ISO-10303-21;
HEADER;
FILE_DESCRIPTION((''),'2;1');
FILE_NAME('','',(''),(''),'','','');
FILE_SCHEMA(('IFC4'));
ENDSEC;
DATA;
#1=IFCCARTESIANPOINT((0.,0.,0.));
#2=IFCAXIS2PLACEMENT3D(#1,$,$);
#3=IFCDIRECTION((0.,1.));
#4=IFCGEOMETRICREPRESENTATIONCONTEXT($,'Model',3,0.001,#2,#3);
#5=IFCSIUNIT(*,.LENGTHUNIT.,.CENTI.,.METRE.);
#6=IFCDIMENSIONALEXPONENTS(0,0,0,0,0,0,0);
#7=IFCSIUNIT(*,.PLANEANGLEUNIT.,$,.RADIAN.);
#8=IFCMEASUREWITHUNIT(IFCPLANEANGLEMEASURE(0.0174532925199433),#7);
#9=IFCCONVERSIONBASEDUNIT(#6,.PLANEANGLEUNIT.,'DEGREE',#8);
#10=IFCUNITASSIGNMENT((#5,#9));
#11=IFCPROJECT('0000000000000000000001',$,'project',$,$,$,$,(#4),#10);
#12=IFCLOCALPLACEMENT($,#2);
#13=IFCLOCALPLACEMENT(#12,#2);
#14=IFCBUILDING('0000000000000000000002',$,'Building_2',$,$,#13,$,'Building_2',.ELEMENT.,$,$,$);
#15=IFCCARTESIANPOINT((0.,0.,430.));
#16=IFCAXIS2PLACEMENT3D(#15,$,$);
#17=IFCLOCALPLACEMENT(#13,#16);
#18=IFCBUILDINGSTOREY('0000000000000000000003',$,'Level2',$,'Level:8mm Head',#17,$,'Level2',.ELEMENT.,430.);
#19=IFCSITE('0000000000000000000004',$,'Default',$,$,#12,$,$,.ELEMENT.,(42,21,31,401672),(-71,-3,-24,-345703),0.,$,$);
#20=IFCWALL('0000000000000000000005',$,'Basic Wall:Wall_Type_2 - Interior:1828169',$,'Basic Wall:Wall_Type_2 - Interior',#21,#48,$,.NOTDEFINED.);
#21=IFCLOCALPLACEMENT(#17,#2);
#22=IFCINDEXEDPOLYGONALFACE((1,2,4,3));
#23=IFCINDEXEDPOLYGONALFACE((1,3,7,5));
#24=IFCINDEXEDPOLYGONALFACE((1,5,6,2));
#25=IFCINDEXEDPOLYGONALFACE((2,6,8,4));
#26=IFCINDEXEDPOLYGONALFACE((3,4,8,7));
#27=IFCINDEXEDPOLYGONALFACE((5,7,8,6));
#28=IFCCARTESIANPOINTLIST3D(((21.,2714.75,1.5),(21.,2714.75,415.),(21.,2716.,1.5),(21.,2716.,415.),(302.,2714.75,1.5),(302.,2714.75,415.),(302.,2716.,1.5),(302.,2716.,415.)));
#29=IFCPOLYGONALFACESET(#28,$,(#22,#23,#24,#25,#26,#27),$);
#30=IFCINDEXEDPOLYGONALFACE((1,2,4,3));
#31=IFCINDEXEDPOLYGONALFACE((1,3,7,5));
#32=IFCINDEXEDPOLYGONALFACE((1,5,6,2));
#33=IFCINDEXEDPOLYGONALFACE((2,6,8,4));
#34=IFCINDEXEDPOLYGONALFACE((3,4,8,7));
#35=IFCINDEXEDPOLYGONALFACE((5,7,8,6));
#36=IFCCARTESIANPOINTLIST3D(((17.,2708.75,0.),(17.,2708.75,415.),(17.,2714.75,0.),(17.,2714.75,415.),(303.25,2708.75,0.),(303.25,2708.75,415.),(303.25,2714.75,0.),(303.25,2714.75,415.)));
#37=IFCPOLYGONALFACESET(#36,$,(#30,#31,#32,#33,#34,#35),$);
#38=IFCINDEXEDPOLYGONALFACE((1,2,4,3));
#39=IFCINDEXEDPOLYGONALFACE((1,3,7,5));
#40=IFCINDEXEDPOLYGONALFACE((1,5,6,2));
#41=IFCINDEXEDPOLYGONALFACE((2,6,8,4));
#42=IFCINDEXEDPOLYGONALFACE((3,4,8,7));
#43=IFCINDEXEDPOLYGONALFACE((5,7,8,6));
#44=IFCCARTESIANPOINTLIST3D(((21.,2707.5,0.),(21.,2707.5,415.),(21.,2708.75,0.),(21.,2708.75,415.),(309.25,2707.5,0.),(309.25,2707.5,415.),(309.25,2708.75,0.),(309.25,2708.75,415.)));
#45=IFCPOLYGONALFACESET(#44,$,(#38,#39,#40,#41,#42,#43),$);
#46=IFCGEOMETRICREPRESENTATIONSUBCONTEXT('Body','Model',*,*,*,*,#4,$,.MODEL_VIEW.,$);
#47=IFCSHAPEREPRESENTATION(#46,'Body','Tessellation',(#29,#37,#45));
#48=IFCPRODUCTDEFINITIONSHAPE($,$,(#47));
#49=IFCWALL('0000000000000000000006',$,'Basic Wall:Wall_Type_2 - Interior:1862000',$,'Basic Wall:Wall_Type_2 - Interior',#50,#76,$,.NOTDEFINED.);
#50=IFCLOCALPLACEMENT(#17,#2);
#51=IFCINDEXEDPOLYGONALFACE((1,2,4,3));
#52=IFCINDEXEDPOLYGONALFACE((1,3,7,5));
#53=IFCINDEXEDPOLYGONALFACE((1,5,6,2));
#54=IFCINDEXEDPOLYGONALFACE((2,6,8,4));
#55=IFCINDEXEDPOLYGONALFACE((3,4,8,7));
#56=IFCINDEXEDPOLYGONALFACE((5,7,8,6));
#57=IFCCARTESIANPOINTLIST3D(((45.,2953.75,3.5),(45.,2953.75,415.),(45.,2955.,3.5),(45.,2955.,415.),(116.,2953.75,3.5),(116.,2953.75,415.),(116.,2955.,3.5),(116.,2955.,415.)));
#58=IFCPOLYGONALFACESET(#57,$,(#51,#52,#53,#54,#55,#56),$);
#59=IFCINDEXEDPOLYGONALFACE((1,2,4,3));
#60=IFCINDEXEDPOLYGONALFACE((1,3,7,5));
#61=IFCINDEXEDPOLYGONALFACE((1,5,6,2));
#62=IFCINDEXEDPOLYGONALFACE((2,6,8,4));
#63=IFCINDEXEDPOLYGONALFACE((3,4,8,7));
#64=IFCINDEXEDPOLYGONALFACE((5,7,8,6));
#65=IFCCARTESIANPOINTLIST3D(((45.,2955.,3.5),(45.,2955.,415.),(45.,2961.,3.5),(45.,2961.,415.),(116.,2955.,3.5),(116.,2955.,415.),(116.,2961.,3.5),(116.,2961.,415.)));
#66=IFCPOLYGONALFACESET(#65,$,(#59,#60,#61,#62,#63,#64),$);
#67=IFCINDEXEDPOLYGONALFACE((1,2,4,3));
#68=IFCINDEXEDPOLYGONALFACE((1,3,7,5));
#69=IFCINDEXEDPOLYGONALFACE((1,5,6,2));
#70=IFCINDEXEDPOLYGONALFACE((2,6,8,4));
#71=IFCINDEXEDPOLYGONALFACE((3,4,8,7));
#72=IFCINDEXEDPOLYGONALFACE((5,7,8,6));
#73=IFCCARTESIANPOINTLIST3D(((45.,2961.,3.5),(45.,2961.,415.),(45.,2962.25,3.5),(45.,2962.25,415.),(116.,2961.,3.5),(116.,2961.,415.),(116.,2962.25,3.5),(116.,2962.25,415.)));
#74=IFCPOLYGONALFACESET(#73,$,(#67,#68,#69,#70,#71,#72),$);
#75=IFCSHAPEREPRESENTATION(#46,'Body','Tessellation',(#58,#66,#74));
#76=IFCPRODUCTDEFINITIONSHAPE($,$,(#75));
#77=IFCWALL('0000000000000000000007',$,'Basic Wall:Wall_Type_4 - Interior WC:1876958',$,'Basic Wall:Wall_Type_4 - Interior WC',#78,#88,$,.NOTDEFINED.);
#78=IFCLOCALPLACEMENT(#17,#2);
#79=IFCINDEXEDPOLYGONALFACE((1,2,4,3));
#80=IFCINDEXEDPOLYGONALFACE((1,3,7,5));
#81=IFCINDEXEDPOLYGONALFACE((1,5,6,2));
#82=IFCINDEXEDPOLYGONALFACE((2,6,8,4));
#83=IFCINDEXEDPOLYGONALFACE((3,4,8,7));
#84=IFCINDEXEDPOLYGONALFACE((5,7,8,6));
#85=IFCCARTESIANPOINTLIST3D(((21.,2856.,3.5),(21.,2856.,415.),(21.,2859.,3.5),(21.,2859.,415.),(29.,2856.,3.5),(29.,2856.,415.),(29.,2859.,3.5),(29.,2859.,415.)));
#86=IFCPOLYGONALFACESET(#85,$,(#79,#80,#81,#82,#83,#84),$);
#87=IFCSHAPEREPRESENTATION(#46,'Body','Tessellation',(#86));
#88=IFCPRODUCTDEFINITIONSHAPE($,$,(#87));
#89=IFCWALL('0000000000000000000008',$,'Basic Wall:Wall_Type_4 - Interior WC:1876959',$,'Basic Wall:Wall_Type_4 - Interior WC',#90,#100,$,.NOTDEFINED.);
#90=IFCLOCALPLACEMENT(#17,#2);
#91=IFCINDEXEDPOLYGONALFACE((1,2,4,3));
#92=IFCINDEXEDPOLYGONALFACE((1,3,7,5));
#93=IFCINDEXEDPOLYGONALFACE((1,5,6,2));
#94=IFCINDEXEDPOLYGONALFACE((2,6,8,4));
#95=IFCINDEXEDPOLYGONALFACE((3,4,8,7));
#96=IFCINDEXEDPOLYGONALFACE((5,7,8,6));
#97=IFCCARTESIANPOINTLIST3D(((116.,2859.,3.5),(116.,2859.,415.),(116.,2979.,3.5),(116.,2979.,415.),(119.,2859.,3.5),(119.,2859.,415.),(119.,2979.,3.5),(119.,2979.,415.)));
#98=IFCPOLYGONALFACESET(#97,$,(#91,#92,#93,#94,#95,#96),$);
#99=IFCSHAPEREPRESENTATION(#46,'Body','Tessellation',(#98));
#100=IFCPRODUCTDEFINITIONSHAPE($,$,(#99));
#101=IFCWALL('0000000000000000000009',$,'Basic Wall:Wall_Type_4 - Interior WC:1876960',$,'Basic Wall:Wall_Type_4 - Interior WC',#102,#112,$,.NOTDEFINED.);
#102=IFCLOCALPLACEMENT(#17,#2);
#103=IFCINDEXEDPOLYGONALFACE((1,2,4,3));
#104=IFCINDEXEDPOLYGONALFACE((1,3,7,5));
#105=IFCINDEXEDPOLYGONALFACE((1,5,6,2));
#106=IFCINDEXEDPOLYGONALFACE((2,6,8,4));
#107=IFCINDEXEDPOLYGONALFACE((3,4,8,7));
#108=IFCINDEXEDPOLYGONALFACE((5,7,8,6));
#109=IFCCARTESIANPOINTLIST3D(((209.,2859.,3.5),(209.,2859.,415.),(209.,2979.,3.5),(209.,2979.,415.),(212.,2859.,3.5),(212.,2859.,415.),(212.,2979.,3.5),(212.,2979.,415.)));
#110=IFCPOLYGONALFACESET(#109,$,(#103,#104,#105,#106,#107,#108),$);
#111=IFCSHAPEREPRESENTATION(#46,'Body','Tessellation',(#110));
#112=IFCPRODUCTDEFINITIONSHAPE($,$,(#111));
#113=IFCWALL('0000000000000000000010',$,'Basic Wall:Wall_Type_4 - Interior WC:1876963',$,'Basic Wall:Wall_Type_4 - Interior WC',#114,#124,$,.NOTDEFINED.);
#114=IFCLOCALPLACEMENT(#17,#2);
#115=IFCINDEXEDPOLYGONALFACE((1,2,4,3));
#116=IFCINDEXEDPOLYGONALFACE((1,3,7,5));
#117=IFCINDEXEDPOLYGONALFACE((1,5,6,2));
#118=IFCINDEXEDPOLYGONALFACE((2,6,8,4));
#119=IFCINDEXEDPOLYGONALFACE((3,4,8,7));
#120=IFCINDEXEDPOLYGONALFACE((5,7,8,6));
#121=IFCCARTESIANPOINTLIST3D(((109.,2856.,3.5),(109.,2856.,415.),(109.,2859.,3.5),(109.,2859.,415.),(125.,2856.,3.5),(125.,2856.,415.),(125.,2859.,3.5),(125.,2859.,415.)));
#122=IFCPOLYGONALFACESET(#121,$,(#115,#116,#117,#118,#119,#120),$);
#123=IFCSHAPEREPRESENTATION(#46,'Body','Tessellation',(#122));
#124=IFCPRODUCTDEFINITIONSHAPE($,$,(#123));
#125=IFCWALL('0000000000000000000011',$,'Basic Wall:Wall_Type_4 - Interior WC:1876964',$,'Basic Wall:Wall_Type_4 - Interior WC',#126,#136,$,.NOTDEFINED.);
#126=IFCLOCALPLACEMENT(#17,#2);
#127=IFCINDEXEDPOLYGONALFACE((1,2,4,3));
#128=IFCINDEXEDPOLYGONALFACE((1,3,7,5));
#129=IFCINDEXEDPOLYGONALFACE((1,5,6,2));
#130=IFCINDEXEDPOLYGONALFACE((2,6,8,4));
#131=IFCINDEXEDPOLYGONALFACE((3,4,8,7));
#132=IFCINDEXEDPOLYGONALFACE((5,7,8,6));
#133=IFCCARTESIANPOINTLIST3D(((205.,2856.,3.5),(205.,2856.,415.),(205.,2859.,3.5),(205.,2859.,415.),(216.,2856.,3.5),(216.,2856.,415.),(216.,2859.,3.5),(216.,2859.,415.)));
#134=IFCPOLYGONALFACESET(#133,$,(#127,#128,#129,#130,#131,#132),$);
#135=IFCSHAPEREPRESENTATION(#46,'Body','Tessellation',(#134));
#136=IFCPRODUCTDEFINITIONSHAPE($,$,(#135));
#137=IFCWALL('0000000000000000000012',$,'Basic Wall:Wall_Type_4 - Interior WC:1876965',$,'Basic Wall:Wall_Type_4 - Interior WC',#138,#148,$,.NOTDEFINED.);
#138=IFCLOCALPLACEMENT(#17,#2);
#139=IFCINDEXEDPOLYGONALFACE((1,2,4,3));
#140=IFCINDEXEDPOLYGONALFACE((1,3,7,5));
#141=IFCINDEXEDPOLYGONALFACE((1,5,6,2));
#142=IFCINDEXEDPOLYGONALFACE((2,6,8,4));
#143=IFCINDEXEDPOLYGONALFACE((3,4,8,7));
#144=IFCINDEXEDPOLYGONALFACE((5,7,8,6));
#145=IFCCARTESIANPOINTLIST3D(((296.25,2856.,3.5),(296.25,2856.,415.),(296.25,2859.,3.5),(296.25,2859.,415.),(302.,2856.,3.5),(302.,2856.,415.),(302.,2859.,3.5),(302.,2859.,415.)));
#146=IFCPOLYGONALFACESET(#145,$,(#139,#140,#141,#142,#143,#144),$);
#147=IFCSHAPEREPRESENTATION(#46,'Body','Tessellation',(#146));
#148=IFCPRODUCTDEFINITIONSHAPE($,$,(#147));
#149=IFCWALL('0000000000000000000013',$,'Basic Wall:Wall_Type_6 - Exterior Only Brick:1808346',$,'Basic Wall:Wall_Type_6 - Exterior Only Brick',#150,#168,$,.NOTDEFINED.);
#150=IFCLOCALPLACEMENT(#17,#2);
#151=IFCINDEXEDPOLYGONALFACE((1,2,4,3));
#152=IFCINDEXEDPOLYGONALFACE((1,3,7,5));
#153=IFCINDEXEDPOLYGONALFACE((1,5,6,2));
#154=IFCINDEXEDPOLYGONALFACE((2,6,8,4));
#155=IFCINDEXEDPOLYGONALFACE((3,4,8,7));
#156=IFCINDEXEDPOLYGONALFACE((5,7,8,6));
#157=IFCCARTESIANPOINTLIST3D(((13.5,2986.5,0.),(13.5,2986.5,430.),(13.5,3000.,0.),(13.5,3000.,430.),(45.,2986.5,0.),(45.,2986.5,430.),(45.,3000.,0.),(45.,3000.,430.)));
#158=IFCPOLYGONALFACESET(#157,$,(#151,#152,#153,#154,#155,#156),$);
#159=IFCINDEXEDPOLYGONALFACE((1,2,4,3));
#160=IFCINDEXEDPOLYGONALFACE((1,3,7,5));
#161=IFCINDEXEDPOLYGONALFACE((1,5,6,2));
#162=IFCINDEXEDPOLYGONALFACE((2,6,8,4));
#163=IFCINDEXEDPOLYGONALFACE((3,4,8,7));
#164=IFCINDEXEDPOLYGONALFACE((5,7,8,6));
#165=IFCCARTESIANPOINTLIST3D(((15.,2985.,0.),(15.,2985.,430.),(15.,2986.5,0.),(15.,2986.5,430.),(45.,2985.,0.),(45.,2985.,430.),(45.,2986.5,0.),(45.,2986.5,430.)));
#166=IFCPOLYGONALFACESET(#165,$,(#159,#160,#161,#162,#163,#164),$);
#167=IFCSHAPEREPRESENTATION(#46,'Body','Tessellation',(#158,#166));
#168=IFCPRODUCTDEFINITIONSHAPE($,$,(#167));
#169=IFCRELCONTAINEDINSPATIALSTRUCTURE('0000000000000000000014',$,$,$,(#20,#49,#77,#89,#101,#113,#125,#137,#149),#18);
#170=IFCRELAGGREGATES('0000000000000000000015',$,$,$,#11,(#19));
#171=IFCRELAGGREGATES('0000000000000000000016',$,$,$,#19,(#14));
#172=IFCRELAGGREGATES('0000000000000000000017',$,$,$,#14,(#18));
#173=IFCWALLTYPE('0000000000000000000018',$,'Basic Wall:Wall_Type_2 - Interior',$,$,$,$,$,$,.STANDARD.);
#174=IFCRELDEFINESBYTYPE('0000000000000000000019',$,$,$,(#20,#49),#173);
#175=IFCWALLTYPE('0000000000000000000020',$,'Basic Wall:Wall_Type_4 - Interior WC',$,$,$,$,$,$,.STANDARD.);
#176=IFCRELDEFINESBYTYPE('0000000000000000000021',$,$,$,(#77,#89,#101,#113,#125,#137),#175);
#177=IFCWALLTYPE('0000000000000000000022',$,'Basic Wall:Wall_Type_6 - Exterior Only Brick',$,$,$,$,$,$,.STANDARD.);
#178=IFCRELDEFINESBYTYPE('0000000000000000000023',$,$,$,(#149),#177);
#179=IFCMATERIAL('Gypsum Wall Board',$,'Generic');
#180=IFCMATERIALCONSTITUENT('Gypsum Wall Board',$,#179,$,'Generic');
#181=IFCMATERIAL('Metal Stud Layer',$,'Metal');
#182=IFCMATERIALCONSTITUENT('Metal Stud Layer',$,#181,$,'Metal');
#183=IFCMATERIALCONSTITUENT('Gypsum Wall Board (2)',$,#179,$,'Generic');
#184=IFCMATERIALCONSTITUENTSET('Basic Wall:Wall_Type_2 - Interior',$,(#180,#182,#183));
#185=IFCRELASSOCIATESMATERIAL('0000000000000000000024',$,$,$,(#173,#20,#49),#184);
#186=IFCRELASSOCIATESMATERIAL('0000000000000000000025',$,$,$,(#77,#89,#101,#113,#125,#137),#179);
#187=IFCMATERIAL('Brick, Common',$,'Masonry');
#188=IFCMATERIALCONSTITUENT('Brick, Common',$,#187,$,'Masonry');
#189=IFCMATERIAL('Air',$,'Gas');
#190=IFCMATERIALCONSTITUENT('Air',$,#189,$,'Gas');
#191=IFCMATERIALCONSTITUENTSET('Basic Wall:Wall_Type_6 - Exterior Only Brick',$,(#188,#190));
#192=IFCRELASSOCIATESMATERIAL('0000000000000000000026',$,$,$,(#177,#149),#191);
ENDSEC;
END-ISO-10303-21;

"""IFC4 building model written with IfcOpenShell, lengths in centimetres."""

from ifc_helpers import new_model, entity, si_unit, converted_unit, direction, frame, origin, place, context, subcontext, project, spatial, indexed_curve, outline, extrude, material, constituent, constituent_set, type_object, element, save


model = new_model("IFC4")

# Units and contexts
model_context = context("Model", 3, precision=0.001, world=origin(), true_north=direction((0.0, 1.0)))
body_context = subcontext(model_context, "Body", "Model", "MODEL_VIEW")
ifc_project = project(units=[si_unit("LENGTHUNIT", "METRE", prefix="CENTI"), converted_unit("PLANEANGLEUNIT", "DEGREE", entity("IfcPlaneAngleMeasure", 0.0174532925199433), si_unit("PLANEANGLEUNIT", "RADIAN"), dimensions=[0, 0, 0, 0, 0, 0, 0])], contexts=[model_context])

# Site, building, storey
site_placement = place(None, origin())
site = spatial("IfcSite", under=ifc_project, at=site_placement, Name="Default", CompositionType="ELEMENT", RefLatitude=(42, 21, 31, 401672), RefLongitude=(-71, -3, -24, -345703), RefElevation=0.0)
building_placement = place(site_placement, origin())
building = spatial("IfcBuilding", under=site, at=building_placement, Name="Building_2", LongName="Building_2", CompositionType="ELEMENT")
storey_placement = place(building_placement, frame((0.0, 0.0, 430.0)))
storey = spatial("IfcBuildingStorey", under=building, at=storey_placement, Name="Level2", ObjectType="Level:8mm Head", LongName="Level2", CompositionType="ELEMENT", Elevation=430.0)

# Shared definitions
ifc_material_1 = material(Name="Brick, Common", Category="Masonry")
ifc_material_2 = material(Name="Air", Category="Gas")
ifc_material_3 = material(Name="Metal Stud Layer", Category="Metal")
ifc_material_4 = material(Name="Gypsum Wall Board", Category="Generic")

# Walls
ifc_constituent_1 = constituent(ifc_material_4, Name="Gypsum Wall Board", Category="Generic")
ifc_constituent_2 = constituent(ifc_material_3, Name="Metal Stud Layer", Category="Metal")
ifc_constituent_3 = constituent(ifc_material_4, Name="Gypsum Wall Board (2)", Category="Generic")
ifc_constituent_set_1 = constituent_set(constituents=[ifc_constituent_1, ifc_constituent_2, ifc_constituent_3], Name="Basic Wall:Wall_Type_2 - Interior")
wall_type_1 = type_object("IfcWallType", Name="Basic Wall:Wall_Type_2 - Interior", PredefinedType="STANDARD", material=ifc_constituent_set_1)
wall_1_placement = place(storey_placement, frame((302.0, 2711.75, 0.0), z_axis=(0.0, 0.0, 1.0), x_axis=(-1.0, 0.0, 0.0)))
element("IfcWall", 1, at=wall_1_placement, inside=storey, type_object=wall_type_1, material=ifc_constituent_set_1, Name="Basic Wall:Wall_Type_2 - Interior:1828169", ObjectType="Basic Wall:Wall_Type_2 - Interior", PredefinedType="NOTDEFINED", context=body_context, shape_type="SweptSolid", body=[
    extrude(outline(indexed_curve([(-0.63, -206.75), (0.62, -206.75), (0.62, 206.75), (-0.63, 206.75), (-0.63, -206.75)], self_intersect=False)), frame((281.0, -3.62, 208.25), z_axis=(-1.0, 0.0, 0.0), x_axis=(0.0, 1.0, 0.0)), (0.0, 0.0, 1.0), 281.0),
    extrude(outline(indexed_curve([(-143.12, -3.0), (143.12, -3.0), (143.12, 3.0), (-143.12, 3.0), (-143.12, -3.0)], self_intersect=False)), frame((141.88, 0.0, 0.0), z_axis=(0.0, 0.0, 1.0), x_axis=(-1.0, 0.0, 0.0)), (0.0, 0.0, 1.0), 415.0),
    extrude(outline(indexed_curve([(-0.63, -144.12), (0.62, -144.12), (0.63, 144.12), (-0.62, 144.12), (-0.63, -144.12)], self_intersect=False)), frame((136.88, 3.63, 0.0), z_axis=(0.0, 0.0, 1.0), x_axis=(0.0, -1.0, 0.0)), (0.0, 0.0, 1.0), 415.0),
])
wall_2_placement = place(storey_placement, frame((45.0, 2958.0, 3.5)))
element("IfcWall", 2, at=wall_2_placement, inside=storey, type_object=wall_type_1, material=ifc_constituent_set_1, Name="Basic Wall:Wall_Type_2 - Interior:1862000", ObjectType="Basic Wall:Wall_Type_2 - Interior", PredefinedType="NOTDEFINED", context=body_context, shape_type="SweptSolid", body=[
    extrude(outline(indexed_curve([(-0.62, -35.5), (0.62, -35.5), (0.63, 35.5), (-0.62, 35.5), (-0.62, -35.5)], self_intersect=False)), frame((35.5, -3.63, 0.0), z_axis=(0.0, 0.0, 1.0), x_axis=(0.0, 1.0, 0.0)), (0.0, 0.0, 1.0), 411.5),
    extrude(outline(indexed_curve([(-35.5, -3.0), (35.5, -3.0), (35.5, 3.0), (-35.5, 3.0), (-35.5, -3.0)], self_intersect=False)), frame((35.5, 0.0, 0.0)), (0.0, 0.0, 1.0), 411.5),
    extrude(outline(indexed_curve([(-0.62, -35.5), (0.63, -35.5), (0.63, 35.5), (-0.62, 35.5), (-0.62, -35.5)], self_intersect=False)), frame((35.5, 3.63, 0.0), z_axis=(0.0, 0.0, 1.0), x_axis=(0.0, -1.0, 0.0)), (0.0, 0.0, 1.0), 411.5),
])
wall_type_2 = type_object("IfcWallType", Name="Basic Wall:Wall_Type_4 - Interior WC", PredefinedType="STANDARD")
wall_3_placement = place(storey_placement, frame((21.0, 2857.5, 3.5)))
element("IfcWall", 3, at=wall_3_placement, inside=storey, type_object=wall_type_2, material=ifc_material_4, Name="Basic Wall:Wall_Type_4 - Interior WC:1876958", ObjectType="Basic Wall:Wall_Type_4 - Interior WC", PredefinedType="NOTDEFINED", context=body_context, shape_type="SweptSolid", body=[
    extrude(outline(indexed_curve([(8.0, 1.5), (0.0, 1.5), (0.0, -1.5), (8.0, -1.5), (8.0, 1.5)], self_intersect=False)), origin(), (0.0, 0.0, 1.0), 411.5),
])
wall_4_placement = place(storey_placement, frame((117.5, 2859.0, 3.5), z_axis=(0.0, 0.0, 1.0), x_axis=(0.0, 1.0, 0.0)))
element("IfcWall", 4, at=wall_4_placement, inside=storey, type_object=wall_type_2, material=ifc_material_4, Name="Basic Wall:Wall_Type_4 - Interior WC:1876959", ObjectType="Basic Wall:Wall_Type_4 - Interior WC", PredefinedType="NOTDEFINED", context=body_context, shape_type="SweptSolid", body=[
    extrude(outline(indexed_curve([(120.0, 1.5), (0.0, 1.5), (0.0, -1.5), (120.0, -1.5), (120.0, 1.5)], self_intersect=False)), origin(), (0.0, 0.0, 1.0), 411.5),
])
wall_5_placement = place(storey_placement, frame((210.5, 2859.0, 3.5), z_axis=(0.0, 0.0, 1.0), x_axis=(0.0, 1.0, 0.0)))
element("IfcWall", 5, at=wall_5_placement, inside=storey, type_object=wall_type_2, material=ifc_material_4, Name="Basic Wall:Wall_Type_4 - Interior WC:1876960", ObjectType="Basic Wall:Wall_Type_4 - Interior WC", PredefinedType="NOTDEFINED", context=body_context, shape_type="SweptSolid", body=[
    extrude(outline(indexed_curve([(120.0, 1.5), (0.0, 1.5), (0.0, -1.5), (120.0, -1.5), (120.0, 1.5)], self_intersect=False)), origin(), (0.0, 0.0, 1.0), 411.5),
])
wall_6_placement = place(storey_placement, frame((109.0, 2857.5, 3.5)))
element("IfcWall", 6, at=wall_6_placement, inside=storey, type_object=wall_type_2, material=ifc_material_4, Name="Basic Wall:Wall_Type_4 - Interior WC:1876963", ObjectType="Basic Wall:Wall_Type_4 - Interior WC", PredefinedType="NOTDEFINED", context=body_context, shape_type="SweptSolid", body=[
    extrude(outline(indexed_curve([(16.0, 1.5), (0.0, 1.5), (0.0, -1.5), (16.0, -1.5), (16.0, 1.5)], self_intersect=False)), origin(), (0.0, 0.0, 1.0), 411.5),
])
wall_7_placement = place(storey_placement, frame((205.0, 2857.5, 3.5)))
element("IfcWall", 7, at=wall_7_placement, inside=storey, type_object=wall_type_2, material=ifc_material_4, Name="Basic Wall:Wall_Type_4 - Interior WC:1876964", ObjectType="Basic Wall:Wall_Type_4 - Interior WC", PredefinedType="NOTDEFINED", context=body_context, shape_type="SweptSolid", body=[
    extrude(outline(indexed_curve([(11.0, 1.5), (0.0, 1.5), (0.0, -1.5), (11.0, -1.5), (11.0, 1.5)], self_intersect=False)), origin(), (0.0, 0.0, 1.0), 411.5),
])
wall_8_placement = place(storey_placement, frame((296.25, 2857.5, 3.5)))
element("IfcWall", 8, at=wall_8_placement, inside=storey, type_object=wall_type_2, material=ifc_material_4, Name="Basic Wall:Wall_Type_4 - Interior WC:1876965", ObjectType="Basic Wall:Wall_Type_4 - Interior WC", PredefinedType="NOTDEFINED", context=body_context, shape_type="SweptSolid", body=[
    extrude(outline(indexed_curve([(5.75, 1.5), (0.0, 1.5), (0.0, -1.5), (5.75, -1.5), (5.75, 1.5)], self_intersect=False)), origin(), (0.0, 0.0, 1.0), 411.5),
])
ifc_constituent_4 = constituent(ifc_material_1, Name="Brick, Common", Category="Masonry")
ifc_constituent_5 = constituent(ifc_material_2, Name="Air", Category="Gas")
ifc_constituent_set_2 = constituent_set(constituents=[ifc_constituent_4, ifc_constituent_5], Name="Basic Wall:Wall_Type_6 - Exterior Only Brick")
wall_type_3 = type_object("IfcWallType", Name="Basic Wall:Wall_Type_6 - Exterior Only Brick", PredefinedType="STANDARD", material=ifc_constituent_set_2)
wall_9_placement = place(storey_placement, frame((15.0, 2992.5, 0.0)))
element("IfcWall", 9, at=wall_9_placement, inside=storey, type_object=wall_type_3, material=ifc_constituent_set_2, Name="Basic Wall:Wall_Type_6 - Exterior Only Brick:1808346", ObjectType="Basic Wall:Wall_Type_6 - Exterior Only Brick", PredefinedType="NOTDEFINED", context=body_context, shape_type="SweptSolid", body=[
    extrude(outline(indexed_curve([(-6.75, -15.75), (6.75, -15.75), (6.75, 15.75), (-6.75, 15.75), (-6.75, -15.75)], self_intersect=False)), frame((14.25, 0.75, 0.0), z_axis=(0.0, 0.0, 1.0), x_axis=(0.0, -1.0, 0.0)), (0.0, 0.0, 1.0), 430.0),
    extrude(outline(indexed_curve([(-0.75, -15.0), (0.75, -15.0), (0.75, 15.0), (-0.75, 15.0), (-0.75, -15.0)], self_intersect=False)), frame((15.0, -6.75, 0.0), z_axis=(0.0, 0.0, 1.0), x_axis=(0.0, 1.0, 0.0)), (0.0, 0.0, 1.0), 430.0),
])

save(model, "model.ifc")
